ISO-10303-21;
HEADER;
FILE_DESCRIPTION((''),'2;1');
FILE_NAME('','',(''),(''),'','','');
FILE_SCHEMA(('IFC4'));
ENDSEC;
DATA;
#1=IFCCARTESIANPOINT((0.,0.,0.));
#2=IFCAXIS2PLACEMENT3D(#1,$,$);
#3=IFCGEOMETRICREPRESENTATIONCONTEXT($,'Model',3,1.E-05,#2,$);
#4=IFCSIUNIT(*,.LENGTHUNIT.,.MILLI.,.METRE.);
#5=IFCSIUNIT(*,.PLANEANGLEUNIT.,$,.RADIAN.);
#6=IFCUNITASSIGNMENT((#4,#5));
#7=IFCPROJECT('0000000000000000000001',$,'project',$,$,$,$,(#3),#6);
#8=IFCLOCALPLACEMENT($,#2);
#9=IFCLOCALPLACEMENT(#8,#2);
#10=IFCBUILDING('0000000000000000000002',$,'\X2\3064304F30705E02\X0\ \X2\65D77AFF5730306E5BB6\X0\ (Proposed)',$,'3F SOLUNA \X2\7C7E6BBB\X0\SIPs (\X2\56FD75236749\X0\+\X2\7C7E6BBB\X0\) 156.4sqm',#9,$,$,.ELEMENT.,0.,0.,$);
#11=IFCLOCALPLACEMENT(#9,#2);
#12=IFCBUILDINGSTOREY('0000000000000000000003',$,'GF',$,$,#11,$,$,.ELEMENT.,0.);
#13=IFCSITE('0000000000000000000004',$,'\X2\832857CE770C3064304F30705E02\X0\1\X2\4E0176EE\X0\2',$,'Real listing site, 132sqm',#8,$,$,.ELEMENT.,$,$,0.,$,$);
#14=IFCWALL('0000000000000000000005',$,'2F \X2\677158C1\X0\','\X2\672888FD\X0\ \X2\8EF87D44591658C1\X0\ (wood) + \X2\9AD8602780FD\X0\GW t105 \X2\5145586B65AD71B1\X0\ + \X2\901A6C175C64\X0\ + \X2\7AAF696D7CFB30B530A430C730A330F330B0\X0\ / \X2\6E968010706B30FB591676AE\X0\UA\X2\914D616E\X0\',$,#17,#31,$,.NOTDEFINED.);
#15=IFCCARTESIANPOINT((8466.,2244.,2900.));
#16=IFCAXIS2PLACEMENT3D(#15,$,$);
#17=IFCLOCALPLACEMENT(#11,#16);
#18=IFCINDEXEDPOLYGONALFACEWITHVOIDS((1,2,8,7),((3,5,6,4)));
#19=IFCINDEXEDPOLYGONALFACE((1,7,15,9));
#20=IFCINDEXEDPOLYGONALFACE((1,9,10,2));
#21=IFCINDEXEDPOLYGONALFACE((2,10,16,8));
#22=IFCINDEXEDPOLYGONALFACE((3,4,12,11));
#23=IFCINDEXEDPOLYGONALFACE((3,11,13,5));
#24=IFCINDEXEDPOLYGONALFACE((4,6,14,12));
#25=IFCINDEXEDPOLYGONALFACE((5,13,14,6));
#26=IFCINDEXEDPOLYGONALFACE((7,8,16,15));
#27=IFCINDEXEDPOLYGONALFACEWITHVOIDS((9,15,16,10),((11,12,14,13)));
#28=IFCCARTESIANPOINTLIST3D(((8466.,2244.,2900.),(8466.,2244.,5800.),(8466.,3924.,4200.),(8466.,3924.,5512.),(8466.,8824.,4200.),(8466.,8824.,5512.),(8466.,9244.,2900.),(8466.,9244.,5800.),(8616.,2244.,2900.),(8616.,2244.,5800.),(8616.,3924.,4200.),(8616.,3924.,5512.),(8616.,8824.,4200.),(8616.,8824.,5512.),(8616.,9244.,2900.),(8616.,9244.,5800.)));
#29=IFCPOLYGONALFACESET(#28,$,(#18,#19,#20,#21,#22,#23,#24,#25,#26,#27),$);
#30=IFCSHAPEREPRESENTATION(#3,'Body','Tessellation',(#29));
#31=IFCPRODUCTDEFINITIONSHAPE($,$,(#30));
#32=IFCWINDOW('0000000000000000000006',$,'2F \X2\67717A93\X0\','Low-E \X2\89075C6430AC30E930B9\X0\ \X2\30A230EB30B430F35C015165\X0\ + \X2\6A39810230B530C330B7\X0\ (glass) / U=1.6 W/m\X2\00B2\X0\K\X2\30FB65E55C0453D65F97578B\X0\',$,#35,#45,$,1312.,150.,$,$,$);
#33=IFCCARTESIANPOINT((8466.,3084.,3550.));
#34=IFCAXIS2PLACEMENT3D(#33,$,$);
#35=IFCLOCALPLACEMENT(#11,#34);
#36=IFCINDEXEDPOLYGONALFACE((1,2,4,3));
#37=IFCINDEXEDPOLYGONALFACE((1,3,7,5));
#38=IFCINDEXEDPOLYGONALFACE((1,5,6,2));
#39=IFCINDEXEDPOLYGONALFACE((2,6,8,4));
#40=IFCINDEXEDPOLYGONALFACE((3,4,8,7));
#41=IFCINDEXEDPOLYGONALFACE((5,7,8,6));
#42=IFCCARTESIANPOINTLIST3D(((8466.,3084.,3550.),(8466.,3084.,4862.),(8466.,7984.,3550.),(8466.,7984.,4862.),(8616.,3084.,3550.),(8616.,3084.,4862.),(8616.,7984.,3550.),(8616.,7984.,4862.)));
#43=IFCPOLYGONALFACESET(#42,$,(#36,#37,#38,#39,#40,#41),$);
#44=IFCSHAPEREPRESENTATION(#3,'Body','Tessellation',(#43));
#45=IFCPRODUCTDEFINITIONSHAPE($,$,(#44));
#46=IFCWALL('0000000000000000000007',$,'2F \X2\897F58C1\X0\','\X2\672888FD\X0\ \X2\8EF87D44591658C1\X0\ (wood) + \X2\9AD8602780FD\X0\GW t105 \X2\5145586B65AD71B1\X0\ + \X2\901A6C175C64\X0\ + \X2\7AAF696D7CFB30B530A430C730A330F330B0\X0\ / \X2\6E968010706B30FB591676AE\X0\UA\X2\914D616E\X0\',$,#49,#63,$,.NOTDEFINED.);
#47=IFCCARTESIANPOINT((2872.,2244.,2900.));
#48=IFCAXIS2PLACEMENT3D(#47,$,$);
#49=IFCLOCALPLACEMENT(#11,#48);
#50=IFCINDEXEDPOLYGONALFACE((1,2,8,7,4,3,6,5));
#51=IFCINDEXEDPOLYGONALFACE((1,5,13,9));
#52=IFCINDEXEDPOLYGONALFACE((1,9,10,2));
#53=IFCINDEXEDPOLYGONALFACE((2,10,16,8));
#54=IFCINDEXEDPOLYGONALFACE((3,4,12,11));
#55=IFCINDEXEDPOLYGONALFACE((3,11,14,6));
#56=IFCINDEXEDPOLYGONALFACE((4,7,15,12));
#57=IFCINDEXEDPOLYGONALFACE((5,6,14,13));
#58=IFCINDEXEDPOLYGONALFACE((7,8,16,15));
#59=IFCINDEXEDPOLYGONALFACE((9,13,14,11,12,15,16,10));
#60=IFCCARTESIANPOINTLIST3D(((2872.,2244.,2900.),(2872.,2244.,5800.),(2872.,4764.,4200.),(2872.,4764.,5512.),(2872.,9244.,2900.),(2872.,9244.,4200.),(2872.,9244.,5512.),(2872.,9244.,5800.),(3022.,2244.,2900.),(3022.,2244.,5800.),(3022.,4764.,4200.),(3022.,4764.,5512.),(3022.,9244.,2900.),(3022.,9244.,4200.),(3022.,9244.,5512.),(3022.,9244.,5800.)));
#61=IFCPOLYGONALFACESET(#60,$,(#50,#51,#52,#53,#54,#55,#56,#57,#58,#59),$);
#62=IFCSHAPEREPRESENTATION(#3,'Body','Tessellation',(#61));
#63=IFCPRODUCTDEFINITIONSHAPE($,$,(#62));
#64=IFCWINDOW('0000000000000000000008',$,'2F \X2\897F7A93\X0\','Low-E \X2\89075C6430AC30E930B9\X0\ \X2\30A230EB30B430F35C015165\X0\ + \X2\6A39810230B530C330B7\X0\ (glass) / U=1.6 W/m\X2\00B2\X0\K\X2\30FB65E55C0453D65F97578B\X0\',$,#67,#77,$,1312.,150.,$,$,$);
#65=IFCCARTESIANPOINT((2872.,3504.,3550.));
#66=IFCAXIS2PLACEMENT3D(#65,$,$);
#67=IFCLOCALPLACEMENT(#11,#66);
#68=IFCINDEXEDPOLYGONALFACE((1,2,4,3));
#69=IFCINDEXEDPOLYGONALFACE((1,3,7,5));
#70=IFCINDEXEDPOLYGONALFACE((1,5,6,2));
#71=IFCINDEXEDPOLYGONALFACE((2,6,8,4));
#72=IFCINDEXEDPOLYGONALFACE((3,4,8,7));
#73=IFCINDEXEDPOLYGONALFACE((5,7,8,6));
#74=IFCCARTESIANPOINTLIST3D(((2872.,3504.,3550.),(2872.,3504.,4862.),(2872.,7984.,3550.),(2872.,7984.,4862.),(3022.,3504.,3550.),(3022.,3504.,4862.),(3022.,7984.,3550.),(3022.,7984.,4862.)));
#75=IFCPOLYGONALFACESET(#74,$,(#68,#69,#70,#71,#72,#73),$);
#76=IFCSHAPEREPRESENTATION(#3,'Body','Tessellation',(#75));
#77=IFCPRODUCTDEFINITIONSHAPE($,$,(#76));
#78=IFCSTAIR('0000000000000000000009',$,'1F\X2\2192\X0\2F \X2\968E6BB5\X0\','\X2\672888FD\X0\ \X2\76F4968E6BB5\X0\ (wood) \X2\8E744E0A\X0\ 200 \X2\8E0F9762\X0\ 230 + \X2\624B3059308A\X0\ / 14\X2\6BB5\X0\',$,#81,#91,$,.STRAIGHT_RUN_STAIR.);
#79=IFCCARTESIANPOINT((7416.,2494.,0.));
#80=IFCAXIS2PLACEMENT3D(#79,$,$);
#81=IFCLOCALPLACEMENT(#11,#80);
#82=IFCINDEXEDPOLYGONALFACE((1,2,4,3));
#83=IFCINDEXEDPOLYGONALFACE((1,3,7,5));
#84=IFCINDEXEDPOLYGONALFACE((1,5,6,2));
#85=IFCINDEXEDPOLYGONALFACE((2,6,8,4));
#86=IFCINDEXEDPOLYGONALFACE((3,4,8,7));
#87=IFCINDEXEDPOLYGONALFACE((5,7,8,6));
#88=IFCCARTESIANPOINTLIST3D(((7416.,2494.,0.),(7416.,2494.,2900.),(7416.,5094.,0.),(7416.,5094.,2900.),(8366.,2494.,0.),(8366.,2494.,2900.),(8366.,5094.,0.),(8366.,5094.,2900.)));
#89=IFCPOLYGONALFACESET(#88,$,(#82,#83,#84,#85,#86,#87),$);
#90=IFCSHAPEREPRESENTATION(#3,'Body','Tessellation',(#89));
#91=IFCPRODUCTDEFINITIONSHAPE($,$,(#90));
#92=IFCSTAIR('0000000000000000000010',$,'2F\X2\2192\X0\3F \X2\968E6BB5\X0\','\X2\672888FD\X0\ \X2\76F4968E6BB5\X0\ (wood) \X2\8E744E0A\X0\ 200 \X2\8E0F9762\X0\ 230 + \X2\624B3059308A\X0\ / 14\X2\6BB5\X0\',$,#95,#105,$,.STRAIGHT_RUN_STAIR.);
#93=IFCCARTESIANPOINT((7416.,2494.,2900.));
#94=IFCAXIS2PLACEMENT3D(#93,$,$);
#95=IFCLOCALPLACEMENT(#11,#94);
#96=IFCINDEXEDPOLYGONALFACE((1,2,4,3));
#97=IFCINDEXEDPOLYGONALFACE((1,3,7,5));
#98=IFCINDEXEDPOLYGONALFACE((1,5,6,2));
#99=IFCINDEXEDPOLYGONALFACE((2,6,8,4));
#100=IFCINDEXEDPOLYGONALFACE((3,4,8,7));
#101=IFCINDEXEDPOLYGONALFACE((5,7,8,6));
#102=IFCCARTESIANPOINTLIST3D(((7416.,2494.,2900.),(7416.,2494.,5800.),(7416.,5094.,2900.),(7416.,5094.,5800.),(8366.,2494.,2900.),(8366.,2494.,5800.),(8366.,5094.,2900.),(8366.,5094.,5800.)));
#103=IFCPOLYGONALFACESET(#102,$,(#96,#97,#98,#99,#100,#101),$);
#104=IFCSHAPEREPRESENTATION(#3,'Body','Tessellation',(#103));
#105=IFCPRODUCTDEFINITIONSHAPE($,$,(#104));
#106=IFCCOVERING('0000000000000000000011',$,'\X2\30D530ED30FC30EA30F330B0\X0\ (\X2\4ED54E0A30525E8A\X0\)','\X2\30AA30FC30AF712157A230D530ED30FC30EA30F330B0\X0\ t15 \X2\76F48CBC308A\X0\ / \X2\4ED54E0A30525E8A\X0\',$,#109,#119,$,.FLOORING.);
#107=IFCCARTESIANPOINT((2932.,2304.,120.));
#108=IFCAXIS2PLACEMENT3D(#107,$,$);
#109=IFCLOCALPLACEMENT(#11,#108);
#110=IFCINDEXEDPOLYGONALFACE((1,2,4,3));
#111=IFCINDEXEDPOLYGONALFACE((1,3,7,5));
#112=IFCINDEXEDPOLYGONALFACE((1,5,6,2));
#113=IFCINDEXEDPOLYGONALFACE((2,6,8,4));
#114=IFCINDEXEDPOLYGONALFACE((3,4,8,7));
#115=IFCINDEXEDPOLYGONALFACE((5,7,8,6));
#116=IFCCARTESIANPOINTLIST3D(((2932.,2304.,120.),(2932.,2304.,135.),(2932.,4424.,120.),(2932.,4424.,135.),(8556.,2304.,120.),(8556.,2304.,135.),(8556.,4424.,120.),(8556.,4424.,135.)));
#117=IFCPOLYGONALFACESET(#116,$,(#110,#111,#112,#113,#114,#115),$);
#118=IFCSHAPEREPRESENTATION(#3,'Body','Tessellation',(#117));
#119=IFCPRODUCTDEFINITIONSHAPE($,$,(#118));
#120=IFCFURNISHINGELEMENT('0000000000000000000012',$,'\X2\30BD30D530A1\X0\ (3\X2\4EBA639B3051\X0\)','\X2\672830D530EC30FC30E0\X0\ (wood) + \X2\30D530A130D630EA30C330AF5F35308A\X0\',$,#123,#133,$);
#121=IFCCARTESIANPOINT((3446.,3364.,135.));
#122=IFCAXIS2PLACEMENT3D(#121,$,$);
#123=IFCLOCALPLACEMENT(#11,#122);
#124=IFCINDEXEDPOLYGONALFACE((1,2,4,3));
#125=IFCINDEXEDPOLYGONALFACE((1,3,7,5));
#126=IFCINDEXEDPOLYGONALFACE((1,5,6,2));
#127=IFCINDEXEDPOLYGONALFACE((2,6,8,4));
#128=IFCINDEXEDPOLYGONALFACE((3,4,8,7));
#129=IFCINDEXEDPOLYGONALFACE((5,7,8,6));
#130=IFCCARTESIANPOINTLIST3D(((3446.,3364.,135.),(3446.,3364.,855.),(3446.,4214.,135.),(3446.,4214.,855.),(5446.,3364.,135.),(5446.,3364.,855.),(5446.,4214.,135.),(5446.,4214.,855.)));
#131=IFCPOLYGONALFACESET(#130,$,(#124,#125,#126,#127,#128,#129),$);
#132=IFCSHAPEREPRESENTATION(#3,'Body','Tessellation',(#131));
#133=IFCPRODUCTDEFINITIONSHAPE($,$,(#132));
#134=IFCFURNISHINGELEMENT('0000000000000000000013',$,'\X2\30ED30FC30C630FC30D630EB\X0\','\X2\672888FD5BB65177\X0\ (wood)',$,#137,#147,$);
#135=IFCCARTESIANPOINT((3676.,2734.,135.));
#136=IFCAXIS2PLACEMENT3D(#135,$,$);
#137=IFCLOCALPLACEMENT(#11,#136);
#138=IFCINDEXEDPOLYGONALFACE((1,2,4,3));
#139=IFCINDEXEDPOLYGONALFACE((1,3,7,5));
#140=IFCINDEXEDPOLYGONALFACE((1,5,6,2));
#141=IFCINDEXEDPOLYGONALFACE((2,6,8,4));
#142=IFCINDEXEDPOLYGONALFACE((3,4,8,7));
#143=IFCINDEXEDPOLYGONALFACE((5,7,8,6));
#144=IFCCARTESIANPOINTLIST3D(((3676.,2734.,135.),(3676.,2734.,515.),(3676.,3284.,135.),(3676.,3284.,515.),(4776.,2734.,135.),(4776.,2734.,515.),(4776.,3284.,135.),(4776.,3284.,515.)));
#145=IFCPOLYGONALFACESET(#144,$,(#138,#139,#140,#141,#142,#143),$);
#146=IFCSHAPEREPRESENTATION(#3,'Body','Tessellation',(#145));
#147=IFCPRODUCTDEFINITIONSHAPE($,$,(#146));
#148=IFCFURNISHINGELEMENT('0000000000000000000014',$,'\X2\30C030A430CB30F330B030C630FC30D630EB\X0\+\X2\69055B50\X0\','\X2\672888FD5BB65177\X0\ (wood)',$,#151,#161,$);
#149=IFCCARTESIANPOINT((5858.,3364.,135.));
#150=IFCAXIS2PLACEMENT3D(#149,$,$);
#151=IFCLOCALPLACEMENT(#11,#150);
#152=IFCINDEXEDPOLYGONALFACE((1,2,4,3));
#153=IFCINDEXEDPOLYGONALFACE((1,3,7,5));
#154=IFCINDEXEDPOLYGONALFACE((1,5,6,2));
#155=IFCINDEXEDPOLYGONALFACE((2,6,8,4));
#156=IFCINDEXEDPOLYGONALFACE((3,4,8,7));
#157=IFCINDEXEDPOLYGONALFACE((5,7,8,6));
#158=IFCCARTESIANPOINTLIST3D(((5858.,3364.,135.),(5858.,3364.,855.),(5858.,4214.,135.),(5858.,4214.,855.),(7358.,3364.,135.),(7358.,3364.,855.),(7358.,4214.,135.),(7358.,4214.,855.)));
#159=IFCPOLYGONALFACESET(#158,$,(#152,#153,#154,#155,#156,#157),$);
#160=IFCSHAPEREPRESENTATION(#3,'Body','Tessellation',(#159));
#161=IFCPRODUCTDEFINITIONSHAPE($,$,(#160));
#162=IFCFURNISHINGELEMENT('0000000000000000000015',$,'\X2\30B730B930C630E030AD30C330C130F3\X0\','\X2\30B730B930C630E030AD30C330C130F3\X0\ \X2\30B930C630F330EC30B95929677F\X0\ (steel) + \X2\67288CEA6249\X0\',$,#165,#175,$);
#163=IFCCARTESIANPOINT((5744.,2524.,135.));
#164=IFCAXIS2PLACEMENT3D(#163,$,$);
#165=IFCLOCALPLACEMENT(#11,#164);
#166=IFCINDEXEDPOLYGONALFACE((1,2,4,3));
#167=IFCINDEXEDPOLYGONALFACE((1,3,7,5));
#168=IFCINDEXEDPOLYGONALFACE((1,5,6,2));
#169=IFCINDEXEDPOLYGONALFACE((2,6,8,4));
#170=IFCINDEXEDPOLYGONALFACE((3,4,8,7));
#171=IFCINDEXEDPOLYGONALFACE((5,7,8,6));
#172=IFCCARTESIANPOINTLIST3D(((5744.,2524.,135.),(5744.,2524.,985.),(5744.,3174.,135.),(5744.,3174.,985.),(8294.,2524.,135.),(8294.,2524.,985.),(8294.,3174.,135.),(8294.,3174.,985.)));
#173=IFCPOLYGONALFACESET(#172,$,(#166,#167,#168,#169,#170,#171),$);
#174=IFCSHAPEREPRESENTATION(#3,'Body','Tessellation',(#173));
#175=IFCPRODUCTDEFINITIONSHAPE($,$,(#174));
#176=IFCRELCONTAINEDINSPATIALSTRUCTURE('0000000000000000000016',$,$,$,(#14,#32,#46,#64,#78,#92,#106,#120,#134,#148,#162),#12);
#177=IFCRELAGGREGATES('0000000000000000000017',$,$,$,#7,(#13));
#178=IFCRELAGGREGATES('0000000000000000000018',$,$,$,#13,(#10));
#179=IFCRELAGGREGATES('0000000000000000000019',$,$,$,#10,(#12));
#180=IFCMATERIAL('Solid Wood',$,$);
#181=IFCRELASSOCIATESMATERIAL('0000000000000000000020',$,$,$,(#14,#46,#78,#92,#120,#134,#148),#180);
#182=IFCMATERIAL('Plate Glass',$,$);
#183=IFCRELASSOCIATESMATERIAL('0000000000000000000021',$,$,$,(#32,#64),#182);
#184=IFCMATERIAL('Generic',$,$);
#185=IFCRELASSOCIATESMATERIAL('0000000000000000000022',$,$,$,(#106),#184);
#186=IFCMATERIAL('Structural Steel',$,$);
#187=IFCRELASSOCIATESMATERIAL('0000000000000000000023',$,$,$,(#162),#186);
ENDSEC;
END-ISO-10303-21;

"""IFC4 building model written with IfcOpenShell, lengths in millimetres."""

from ifc_helpers import new_model, si_unit, frame, frame_2d, origin, place, context, project, spatial, rectangle, extrude, material, element, fill, save


model = new_model("IFC4")

# Units and contexts
model_context = context("Model", 3, precision=1e-05, world=origin())
ifc_project = project(units=[si_unit("LENGTHUNIT", "METRE", prefix="MILLI"), si_unit("PLANEANGLEUNIT", "RADIAN")], contexts=[model_context])

# Site, building, storey
site_placement = place(None, origin())
site = spatial("IfcSite", under=ifc_project, at=site_placement, Name="茨城県つくば市1丁目2", ObjectType="Real listing site, 132sqm", CompositionType="ELEMENT", RefElevation=0.0)
building_placement = place(site_placement, origin())
building = spatial("IfcBuilding", under=site, at=building_placement, Name="つくば市 旗竿地の家 (Proposed)", ObjectType="3F SOLUNA 籾殻SIPs (国産杉+籾殻) 156.4sqm", CompositionType="ELEMENT", ElevationOfRefHeight=0.0, ElevationOfTerrain=0.0)
storey_placement = place(building_placement, origin())
storey = spatial("IfcBuildingStorey", under=building, at=storey_placement, Name="GF", CompositionType="ELEMENT", Elevation=0.0)

# Shared definitions
ifc_material_1 = material(Name="Solid Wood")
ifc_material_2 = material(Name="Generic")

# Shared definitions
ifc_material_3 = material(Name="Plate Glass")

# Walls, openings, windows
wall_1_placement = place(storey_placement, frame((8466.0, 2244.0, 2900.0)))
wall_1 = element("IfcWall", 1, at=wall_1_placement, inside=storey, material=ifc_material_1, Name="2F 東壁", Description="木製 軸組外壁 (wood) + 高性能GW t105 充填断熱 + 通気層 + 窯業系サイディング / 準耐火・外皮UA配慮", PredefinedType="NOTDEFINED", context=model_context, shape_type="SweptSolid", body=[
    extrude(rectangle(XDim=150.0, YDim=7000.0, at=frame_2d((75.0, 3500.0))), frame((8466.0, 2244.0, 2900.0)), (0.0, 0.0, 1.0), 2900.0),
])
opening_1_placement = place(storey_placement, frame((8466.0, 3084.0, 3550.0)))
opening_1 = element("IfcOpeningElement", 2, at=opening_1_placement, cuts=wall_1, PredefinedType="NOTDEFINED", context=model_context, shape_type="SweptSolid", body=[
    extrude(rectangle(XDim=150.0, YDim=4900.0, at=frame_2d((75.0, 2450.0))), frame((8466.0, 3084.0, 3550.0)), (0.0, 0.0, 1.0), 1312.0),
])
window_1_placement = place(storey_placement, frame((8466.0, 3084.0, 3550.0)))
window_1 = element("IfcWindow", 3, at=window_1_placement, inside=storey, material=ifc_material_3, Name="2F 東窓", Description="Low-E 複層ガラス アルゴン封入 + 樹脂サッシ (glass) / U=1.6 W/m²K・日射取得型", OverallHeight=1312.0, OverallWidth=150.0, context=model_context, shape_type="SweptSolid", body=[
    extrude(rectangle(XDim=150.0, YDim=4900.0, at=frame_2d((75.0, 2450.0))), frame((8466.0, 3084.0, 3550.0)), (0.0, 0.0, 1.0), 1312.0),
])
fill(opening_1, window_1)
wall_2_placement = place(storey_placement, frame((2872.0, 2244.0, 2900.0)))
wall_2 = element("IfcWall", 4, at=wall_2_placement, inside=storey, material=ifc_material_1, Name="2F 西壁", Description="木製 軸組外壁 (wood) + 高性能GW t105 充填断熱 + 通気層 + 窯業系サイディング / 準耐火・外皮UA配慮", PredefinedType="NOTDEFINED", context=model_context, shape_type="SweptSolid", body=[
    extrude(rectangle(XDim=150.0, YDim=7000.0, at=frame_2d((75.0, 3500.0))), frame((2872.0, 2244.0, 2900.0)), (0.0, 0.0, 1.0), 2900.0),
])
opening_2_placement = place(storey_placement, frame((2872.0, 3504.0, 3550.0)))
opening_2 = element("IfcOpeningElement", 5, at=opening_2_placement, cuts=wall_2, PredefinedType="NOTDEFINED", context=model_context, shape_type="SweptSolid", body=[
    extrude(rectangle(XDim=150.0, YDim=4480.0, at=frame_2d((75.0, 2240.0))), frame((2872.0, 3504.0, 3550.0)), (0.0, 0.0, 1.0), 1312.0),
])
window_2_placement = place(storey_placement, frame((2872.0, 3504.0, 3550.0)))
window_2 = element("IfcWindow", 6, at=window_2_placement, inside=storey, material=ifc_material_3, Name="2F 西窓", Description="Low-E 複層ガラス アルゴン封入 + 樹脂サッシ (glass) / U=1.6 W/m²K・日射取得型", OverallHeight=1312.0, OverallWidth=150.0, context=model_context, shape_type="SweptSolid", body=[
    extrude(rectangle(XDim=150.0, YDim=4480.0, at=frame_2d((75.0, 2240.0))), frame((2872.0, 3504.0, 3550.0)), (0.0, 0.0, 1.0), 1312.0),
])
fill(opening_2, window_2)

# Stairs
stair_1_placement = place(storey_placement, frame((7416.0, 2494.0, 0.0)))
element("IfcStair", 7, at=stair_1_placement, inside=storey, material=ifc_material_1, Name="1F→2F 階段", Description="木製 直階段 (wood) 蹴上 200 踏面 230 + 手すり / 14段", PredefinedType="STRAIGHT_RUN_STAIR", context=model_context, shape_type="SweptSolid", body=[
    extrude(rectangle(XDim=950.0, YDim=2600.0, at=frame_2d((475.0, 1300.0))), frame((7416.0, 2494.0, 0.0)), (0.0, 0.0, 1.0), 2900.0),
])
stair_2_placement = place(storey_placement, frame((7416.0, 2494.0, 2900.0)))
element("IfcStair", 8, at=stair_2_placement, inside=storey, material=ifc_material_1, Name="2F→3F 階段", Description="木製 直階段 (wood) 蹴上 200 踏面 230 + 手すり / 14段", PredefinedType="STRAIGHT_RUN_STAIR", context=model_context, shape_type="SweptSolid", body=[
    extrude(rectangle(XDim=950.0, YDim=2600.0, at=frame_2d((475.0, 1300.0))), frame((7416.0, 2494.0, 2900.0)), (0.0, 0.0, 1.0), 2900.0),
])

# Covering
covering_placement = place(storey_placement, frame((2932.0, 2304.0, 120.0)))
element("IfcCovering", 9, at=covering_placement, inside=storey, material=ifc_material_2, Name="フローリング (仕上げ床)", Description="オーク無垢フローリング t15 直貼り / 仕上げ床", PredefinedType="FLOORING", context=model_context, shape_type="SweptSolid", body=[
    extrude(rectangle(XDim=5624.0, YDim=2120.0, at=frame_2d((2812.0, 1060.0))), frame((2932.0, 2304.0, 120.0)), (0.0, 0.0, 1.0), 15.0),
])

# Furnishing elements
furnishing_1_placement = place(storey_placement, frame((3446.0, 3364.0, 135.0)))
element("IfcFurnishingElement", 10, at=furnishing_1_placement, inside=storey, material=ifc_material_1, Name="ソファ (3人掛け)", Description="木フレーム (wood) + ファブリック張り", context=model_context, shape_type="SweptSolid", body=[
    extrude(rectangle(XDim=2000.0, YDim=850.0, at=frame_2d((1000.0, 425.0))), frame((3446.0, 3364.0, 135.0)), (0.0, 0.0, 1.0), 720.0),
])
furnishing_2_placement = place(storey_placement, frame((3676.0, 2734.0, 135.0)))
element("IfcFurnishingElement", 11, at=furnishing_2_placement, inside=storey, material=ifc_material_1, Name="ローテーブル", Description="木製家具 (wood)", context=model_context, shape_type="SweptSolid", body=[
    extrude(rectangle(XDim=1100.0, YDim=550.0, at=frame_2d((550.0, 275.0))), frame((3676.0, 2734.0, 135.0)), (0.0, 0.0, 1.0), 380.0),
])
furnishing_3_placement = place(storey_placement, frame((5858.0, 3364.0, 135.0)))
element("IfcFurnishingElement", 12, at=furnishing_3_placement, inside=storey, material=ifc_material_1, Name="ダイニングテーブル+椅子", Description="木製家具 (wood)", context=model_context, shape_type="SweptSolid", body=[
    extrude(rectangle(XDim=1500.0, YDim=850.0, at=frame_2d((750.0, 425.0))), frame((5858.0, 3364.0, 135.0)), (0.0, 0.0, 1.0), 720.0),
])
ifc_material_4 = material(Name="Structural Steel")
furnishing_4_placement = place(storey_placement, frame((5744.0, 2524.0, 135.0)))
element("IfcFurnishingElement", 13, at=furnishing_4_placement, inside=storey, material=ifc_material_4, Name="システムキッチン", Description="システムキッチン ステンレス天板 (steel) + 木質扉", context=model_context, shape_type="SweptSolid", body=[
    extrude(rectangle(XDim=2550.0, YDim=650.0, at=frame_2d((1275.0, 325.0))), frame((5744.0, 2524.0, 135.0)), (0.0, 0.0, 1.0), 850.0),
])

save(model, "model.ifc")
